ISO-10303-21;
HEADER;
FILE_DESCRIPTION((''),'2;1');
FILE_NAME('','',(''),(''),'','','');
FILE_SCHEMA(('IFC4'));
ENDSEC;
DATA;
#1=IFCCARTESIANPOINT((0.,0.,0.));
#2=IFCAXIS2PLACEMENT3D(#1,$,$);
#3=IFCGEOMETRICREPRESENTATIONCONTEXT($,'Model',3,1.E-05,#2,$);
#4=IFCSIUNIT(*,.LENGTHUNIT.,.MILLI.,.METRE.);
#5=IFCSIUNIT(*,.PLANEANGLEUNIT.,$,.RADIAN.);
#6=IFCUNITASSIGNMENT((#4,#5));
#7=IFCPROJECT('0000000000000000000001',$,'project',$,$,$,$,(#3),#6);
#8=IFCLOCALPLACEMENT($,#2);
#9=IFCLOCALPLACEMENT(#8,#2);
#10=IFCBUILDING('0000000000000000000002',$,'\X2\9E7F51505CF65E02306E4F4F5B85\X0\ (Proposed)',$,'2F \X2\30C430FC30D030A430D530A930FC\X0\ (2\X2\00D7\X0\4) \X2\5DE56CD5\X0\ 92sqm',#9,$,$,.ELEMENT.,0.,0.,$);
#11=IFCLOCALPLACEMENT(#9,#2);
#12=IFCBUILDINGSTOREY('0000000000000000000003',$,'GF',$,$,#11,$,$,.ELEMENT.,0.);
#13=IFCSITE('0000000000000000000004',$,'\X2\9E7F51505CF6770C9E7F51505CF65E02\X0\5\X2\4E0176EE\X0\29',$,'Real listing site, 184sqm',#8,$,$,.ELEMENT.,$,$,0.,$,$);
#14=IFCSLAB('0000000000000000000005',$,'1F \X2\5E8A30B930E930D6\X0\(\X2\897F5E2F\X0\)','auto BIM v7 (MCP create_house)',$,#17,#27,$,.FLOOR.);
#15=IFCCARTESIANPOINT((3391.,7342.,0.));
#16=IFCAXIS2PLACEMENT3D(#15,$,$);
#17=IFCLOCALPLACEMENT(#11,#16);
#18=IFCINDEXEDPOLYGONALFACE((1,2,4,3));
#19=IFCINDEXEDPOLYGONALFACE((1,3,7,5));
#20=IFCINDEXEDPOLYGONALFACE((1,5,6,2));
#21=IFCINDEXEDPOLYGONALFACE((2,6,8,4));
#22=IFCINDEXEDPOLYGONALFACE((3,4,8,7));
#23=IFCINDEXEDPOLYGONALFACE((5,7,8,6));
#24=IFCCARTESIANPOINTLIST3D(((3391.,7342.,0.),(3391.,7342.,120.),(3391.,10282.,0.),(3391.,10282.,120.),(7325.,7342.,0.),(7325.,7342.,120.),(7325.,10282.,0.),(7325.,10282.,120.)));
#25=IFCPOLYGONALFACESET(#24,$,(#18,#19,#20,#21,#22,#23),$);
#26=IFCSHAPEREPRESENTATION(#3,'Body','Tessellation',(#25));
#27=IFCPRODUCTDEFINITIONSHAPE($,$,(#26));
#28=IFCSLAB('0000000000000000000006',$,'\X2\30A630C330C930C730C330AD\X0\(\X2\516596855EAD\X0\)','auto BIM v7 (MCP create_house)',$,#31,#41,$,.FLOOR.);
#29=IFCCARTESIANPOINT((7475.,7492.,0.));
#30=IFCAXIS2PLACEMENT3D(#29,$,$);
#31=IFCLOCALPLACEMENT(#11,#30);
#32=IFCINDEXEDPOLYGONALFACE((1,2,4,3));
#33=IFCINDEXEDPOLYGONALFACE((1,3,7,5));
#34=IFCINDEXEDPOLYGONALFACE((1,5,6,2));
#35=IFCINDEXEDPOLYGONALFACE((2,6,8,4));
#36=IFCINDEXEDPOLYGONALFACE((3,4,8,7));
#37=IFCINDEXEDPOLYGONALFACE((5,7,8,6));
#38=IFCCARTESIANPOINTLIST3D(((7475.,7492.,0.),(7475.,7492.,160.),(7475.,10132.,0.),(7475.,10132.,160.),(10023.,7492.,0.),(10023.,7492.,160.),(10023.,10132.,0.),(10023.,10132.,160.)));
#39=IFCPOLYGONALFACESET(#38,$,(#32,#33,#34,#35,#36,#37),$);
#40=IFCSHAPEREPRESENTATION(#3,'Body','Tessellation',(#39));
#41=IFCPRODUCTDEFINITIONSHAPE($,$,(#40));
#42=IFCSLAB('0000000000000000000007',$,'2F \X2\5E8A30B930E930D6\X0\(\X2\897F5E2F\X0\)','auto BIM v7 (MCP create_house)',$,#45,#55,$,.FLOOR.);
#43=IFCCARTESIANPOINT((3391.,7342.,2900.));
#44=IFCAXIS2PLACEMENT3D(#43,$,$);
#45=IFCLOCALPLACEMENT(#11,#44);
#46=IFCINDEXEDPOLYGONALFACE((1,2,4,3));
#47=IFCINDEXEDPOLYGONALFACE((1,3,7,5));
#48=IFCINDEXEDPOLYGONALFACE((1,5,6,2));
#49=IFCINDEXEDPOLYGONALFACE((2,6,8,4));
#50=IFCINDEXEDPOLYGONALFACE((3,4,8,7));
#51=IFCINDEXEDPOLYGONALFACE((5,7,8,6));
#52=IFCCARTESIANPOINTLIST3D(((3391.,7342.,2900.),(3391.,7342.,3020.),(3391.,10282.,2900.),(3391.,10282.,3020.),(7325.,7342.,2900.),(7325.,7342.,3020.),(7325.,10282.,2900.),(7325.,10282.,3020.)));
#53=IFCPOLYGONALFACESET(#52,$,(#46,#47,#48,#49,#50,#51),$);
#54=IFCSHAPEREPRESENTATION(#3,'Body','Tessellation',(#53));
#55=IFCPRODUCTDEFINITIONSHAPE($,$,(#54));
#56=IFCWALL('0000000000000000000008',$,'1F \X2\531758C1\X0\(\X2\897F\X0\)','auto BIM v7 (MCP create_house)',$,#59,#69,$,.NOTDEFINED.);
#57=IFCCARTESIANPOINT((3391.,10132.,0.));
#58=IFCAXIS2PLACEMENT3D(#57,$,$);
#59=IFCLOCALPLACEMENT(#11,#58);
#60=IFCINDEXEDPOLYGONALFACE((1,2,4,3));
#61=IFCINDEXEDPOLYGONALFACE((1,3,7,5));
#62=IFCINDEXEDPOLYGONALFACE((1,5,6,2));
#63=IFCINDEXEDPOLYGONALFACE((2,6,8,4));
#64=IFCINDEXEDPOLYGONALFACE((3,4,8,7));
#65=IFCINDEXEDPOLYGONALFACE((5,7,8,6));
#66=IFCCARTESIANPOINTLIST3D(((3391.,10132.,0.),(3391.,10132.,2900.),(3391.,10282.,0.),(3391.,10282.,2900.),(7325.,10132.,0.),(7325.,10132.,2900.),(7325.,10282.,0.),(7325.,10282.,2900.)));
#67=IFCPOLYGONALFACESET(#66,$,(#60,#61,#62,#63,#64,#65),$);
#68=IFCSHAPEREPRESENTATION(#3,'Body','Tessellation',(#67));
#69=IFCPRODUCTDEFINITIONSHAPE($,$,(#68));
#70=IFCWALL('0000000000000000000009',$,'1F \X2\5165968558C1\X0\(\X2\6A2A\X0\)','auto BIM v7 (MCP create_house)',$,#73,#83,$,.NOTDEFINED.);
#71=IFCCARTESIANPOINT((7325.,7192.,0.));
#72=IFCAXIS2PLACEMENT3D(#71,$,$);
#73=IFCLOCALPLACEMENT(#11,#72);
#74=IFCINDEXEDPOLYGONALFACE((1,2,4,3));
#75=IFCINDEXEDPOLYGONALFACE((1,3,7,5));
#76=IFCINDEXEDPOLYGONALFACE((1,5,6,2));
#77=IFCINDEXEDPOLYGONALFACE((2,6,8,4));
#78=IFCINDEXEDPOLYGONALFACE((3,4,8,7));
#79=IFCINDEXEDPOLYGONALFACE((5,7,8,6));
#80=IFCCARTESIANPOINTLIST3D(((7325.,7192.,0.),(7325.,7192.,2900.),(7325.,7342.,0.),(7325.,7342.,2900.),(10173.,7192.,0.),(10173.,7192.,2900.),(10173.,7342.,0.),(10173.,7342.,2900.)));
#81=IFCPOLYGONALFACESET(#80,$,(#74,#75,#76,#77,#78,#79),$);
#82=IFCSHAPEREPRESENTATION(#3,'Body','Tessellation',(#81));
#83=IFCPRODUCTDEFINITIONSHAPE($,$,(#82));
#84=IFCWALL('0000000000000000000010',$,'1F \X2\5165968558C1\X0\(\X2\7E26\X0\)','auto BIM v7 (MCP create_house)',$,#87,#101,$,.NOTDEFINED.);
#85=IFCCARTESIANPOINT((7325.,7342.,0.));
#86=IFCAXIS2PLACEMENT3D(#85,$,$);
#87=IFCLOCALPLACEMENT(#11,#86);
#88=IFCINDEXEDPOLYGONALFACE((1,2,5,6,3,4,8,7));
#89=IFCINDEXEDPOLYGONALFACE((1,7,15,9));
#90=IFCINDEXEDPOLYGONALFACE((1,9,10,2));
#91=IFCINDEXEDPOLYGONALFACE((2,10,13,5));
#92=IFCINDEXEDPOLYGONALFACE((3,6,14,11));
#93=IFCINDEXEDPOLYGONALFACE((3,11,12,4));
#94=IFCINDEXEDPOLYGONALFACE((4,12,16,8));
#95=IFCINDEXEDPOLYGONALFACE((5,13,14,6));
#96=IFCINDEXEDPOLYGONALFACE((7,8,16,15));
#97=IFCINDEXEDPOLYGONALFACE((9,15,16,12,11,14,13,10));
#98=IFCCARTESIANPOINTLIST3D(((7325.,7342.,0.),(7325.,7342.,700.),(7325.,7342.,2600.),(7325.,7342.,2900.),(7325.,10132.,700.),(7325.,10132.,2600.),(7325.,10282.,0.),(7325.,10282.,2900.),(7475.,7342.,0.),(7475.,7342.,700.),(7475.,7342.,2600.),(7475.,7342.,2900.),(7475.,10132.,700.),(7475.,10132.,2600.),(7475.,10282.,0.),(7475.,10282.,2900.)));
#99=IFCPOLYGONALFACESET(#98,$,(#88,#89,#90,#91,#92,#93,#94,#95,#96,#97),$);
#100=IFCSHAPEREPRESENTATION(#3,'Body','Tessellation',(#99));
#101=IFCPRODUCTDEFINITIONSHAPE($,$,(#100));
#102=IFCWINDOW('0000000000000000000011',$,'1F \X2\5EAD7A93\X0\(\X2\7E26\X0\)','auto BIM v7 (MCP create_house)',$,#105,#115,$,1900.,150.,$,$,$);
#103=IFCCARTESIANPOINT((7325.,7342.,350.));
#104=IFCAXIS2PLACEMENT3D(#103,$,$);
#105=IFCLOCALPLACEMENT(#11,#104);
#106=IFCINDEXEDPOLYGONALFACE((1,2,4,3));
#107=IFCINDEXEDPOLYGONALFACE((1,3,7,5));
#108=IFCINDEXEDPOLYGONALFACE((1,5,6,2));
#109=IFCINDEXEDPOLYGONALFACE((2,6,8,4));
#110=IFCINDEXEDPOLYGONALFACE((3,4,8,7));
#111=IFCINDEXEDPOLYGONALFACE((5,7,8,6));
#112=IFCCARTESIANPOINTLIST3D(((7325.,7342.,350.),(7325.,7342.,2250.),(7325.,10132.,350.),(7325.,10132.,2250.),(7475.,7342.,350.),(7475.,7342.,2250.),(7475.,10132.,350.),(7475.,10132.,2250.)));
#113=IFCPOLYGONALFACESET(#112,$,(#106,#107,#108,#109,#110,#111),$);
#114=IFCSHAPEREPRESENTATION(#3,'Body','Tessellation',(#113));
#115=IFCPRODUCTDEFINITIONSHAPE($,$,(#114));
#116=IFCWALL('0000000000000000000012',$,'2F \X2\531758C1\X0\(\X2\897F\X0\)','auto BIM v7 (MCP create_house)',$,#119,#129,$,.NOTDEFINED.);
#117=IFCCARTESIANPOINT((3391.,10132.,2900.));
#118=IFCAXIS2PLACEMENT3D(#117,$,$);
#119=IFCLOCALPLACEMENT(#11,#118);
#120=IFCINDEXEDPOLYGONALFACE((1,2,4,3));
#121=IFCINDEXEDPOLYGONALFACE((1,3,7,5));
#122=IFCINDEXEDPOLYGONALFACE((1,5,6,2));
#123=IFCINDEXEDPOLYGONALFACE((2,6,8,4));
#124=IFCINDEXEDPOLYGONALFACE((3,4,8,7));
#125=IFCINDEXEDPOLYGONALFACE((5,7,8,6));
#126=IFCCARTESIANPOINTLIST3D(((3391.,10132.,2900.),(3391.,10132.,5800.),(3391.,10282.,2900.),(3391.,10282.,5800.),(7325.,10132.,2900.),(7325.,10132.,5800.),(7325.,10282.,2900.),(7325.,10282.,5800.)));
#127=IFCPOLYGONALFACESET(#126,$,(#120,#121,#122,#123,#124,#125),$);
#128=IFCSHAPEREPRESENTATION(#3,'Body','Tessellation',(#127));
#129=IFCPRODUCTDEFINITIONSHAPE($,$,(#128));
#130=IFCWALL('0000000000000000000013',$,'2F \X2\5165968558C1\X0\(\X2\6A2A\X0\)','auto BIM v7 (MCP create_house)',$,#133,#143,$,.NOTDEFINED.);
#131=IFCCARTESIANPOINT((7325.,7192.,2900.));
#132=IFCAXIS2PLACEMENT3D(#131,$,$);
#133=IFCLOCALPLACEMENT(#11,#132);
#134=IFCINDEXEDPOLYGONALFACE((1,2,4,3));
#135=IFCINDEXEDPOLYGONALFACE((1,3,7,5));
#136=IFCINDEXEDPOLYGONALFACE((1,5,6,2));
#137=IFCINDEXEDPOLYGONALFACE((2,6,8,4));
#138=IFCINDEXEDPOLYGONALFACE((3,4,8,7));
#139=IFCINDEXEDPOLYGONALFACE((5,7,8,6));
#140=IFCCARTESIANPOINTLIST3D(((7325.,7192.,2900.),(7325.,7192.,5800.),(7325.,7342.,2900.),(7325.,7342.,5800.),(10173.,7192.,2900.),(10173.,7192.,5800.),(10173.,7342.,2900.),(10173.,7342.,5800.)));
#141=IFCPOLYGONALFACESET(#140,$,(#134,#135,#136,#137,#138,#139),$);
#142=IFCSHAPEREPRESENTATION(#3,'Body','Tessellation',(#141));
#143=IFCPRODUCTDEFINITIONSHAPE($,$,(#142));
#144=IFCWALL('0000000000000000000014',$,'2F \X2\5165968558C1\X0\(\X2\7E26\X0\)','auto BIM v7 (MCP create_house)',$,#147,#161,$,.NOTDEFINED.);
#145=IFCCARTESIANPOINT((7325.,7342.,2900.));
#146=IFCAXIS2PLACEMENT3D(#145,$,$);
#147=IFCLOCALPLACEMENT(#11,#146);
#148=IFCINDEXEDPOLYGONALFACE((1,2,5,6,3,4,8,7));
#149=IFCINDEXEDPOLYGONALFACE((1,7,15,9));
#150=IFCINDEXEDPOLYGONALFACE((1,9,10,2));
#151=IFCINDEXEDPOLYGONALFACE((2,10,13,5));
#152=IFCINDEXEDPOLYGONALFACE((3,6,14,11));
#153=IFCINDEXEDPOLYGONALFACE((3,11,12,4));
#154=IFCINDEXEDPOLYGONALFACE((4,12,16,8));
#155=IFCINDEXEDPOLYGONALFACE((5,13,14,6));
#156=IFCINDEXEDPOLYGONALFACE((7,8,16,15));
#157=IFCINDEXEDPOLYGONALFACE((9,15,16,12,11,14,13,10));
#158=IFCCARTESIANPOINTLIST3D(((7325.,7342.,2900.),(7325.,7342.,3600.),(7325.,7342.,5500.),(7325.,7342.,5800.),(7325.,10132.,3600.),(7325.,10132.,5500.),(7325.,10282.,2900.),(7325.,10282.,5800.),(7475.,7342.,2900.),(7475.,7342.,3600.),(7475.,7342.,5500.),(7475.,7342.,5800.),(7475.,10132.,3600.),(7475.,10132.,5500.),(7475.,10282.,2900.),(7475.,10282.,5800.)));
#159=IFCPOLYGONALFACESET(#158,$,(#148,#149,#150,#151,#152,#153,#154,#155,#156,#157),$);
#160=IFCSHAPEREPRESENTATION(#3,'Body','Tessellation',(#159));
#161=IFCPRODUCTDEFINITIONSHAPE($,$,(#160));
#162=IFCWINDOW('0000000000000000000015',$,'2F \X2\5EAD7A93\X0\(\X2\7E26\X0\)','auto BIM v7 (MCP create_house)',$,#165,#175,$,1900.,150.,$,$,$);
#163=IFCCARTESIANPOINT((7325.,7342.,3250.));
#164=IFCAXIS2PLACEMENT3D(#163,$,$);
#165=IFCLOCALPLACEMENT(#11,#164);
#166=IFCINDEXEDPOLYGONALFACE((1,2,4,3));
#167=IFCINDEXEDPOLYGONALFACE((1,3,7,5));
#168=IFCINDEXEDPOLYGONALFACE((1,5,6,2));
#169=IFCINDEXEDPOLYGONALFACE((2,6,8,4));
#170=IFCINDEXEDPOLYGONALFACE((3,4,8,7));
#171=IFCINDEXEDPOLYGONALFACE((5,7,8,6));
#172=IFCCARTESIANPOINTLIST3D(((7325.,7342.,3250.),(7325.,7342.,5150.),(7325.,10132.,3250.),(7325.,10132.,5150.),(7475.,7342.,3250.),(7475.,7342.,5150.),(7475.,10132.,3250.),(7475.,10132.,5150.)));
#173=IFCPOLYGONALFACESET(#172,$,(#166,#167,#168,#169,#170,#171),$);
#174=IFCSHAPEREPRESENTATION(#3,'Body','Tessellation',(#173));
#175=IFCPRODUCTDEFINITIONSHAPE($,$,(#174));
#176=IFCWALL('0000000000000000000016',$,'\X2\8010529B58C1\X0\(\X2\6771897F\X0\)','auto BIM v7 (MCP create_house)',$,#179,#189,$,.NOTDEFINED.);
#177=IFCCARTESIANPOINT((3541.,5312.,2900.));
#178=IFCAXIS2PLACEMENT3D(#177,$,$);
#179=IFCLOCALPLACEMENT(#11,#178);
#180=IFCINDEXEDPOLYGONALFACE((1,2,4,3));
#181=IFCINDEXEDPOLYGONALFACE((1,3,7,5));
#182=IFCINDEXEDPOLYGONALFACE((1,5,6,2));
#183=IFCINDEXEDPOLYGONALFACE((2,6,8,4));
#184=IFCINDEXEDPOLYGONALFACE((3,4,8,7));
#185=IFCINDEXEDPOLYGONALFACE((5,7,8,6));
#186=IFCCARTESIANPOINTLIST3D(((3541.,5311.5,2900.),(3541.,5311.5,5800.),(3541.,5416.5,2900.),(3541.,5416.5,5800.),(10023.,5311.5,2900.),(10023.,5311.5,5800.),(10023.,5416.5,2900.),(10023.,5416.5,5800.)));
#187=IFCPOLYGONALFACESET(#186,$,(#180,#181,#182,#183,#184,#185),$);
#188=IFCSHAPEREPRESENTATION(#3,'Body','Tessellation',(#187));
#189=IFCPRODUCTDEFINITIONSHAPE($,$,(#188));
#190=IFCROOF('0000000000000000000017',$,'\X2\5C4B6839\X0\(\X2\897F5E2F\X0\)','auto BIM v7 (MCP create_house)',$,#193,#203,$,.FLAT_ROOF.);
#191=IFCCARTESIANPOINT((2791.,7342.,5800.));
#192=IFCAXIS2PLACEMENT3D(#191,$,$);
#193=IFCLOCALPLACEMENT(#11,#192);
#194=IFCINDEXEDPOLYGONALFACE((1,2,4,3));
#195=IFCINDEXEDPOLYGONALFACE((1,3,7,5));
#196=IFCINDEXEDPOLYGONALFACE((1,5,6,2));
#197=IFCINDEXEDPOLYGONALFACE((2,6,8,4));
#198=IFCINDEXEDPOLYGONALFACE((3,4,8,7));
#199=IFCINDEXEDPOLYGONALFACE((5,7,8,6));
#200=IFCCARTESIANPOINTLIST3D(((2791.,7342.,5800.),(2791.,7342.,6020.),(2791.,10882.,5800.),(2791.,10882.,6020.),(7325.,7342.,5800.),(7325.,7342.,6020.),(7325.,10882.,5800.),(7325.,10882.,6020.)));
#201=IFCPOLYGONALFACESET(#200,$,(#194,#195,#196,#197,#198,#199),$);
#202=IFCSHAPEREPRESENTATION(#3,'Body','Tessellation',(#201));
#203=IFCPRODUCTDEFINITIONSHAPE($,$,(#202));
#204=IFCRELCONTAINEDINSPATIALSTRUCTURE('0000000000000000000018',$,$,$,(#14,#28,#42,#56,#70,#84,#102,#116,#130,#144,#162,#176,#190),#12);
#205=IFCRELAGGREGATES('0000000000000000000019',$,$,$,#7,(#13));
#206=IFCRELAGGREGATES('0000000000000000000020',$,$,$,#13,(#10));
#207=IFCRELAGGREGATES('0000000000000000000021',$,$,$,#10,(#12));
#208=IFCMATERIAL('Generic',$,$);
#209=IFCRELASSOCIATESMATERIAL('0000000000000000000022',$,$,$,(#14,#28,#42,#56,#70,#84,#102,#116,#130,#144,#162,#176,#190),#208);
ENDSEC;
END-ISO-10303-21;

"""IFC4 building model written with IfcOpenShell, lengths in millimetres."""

from ifc_helpers import new_model, si_unit, frame, frame_2d, origin, place, context, project, spatial, rectangle, extrude, material, element, fill, save


model = new_model("IFC4")

# Units and contexts
model_context = context("Model", 3, precision=1e-05, world=origin())
ifc_project = project(units=[si_unit("LENGTHUNIT", "METRE", prefix="MILLI"), si_unit("PLANEANGLEUNIT", "RADIAN")], contexts=[model_context])

# Site, building, storey
site_placement = place(None, origin())
site = spatial("IfcSite", under=ifc_project, at=site_placement, Name="鹿児島県鹿児島市5丁目29", ObjectType="Real listing site, 184sqm", CompositionType="ELEMENT", RefElevation=0.0)
building_placement = place(site_placement, origin())
building = spatial("IfcBuilding", under=site, at=building_placement, Name="鹿児島市の住宅 (Proposed)", ObjectType="2F ツーバイフォー (2×4) 工法 92sqm", CompositionType="ELEMENT", ElevationOfRefHeight=0.0, ElevationOfTerrain=0.0)
storey_placement = place(building_placement, origin())
storey = spatial("IfcBuildingStorey", under=building, at=storey_placement, Name="GF", CompositionType="ELEMENT", Elevation=0.0)

# Slabs
ifc_material = material(Name="Generic")
slab_1_placement = place(storey_placement, frame((3391.0, 7342.0, 0.0)))
element("IfcSlab", 1, at=slab_1_placement, inside=storey, material=ifc_material, Name="1F 床スラブ(西帯)", Description="auto BIM v7 (MCP create_house)", PredefinedType="FLOOR", context=model_context, shape_type="SweptSolid", body=[
    extrude(rectangle(XDim=3934.0, YDim=2940.0, at=frame_2d((1967.0, 1470.0))), frame((3391.0, 7342.0, 0.0)), (0.0, 0.0, 1.0), 120.0),
])
slab_2_placement = place(storey_placement, frame((7475.0, 7492.0, 0.0)))
element("IfcSlab", 2, at=slab_2_placement, inside=storey, material=ifc_material, Name="ウッドデッキ(入隅庭)", Description="auto BIM v7 (MCP create_house)", PredefinedType="FLOOR", context=model_context, shape_type="SweptSolid", body=[
    extrude(rectangle(XDim=2548.0, YDim=2640.0, at=frame_2d((1274.0, 1320.0))), frame((7475.0, 7492.0, 0.0)), (0.0, 0.0, 1.0), 160.0),
])
slab_3_placement = place(storey_placement, frame((3391.0, 7342.0, 2900.0)))
element("IfcSlab", 3, at=slab_3_placement, inside=storey, material=ifc_material, Name="2F 床スラブ(西帯)", Description="auto BIM v7 (MCP create_house)", PredefinedType="FLOOR", context=model_context, shape_type="SweptSolid", body=[
    extrude(rectangle(XDim=3934.0, YDim=2940.0, at=frame_2d((1967.0, 1470.0))), frame((3391.0, 7342.0, 2900.0)), (0.0, 0.0, 1.0), 120.0),
])

# Walls
wall_1_placement = place(storey_placement, frame((3391.0, 10132.0, 0.0)))
element("IfcWall", 4, at=wall_1_placement, inside=storey, material=ifc_material, Name="1F 北壁(西)", Description="auto BIM v7 (MCP create_house)", PredefinedType="NOTDEFINED", context=model_context, shape_type="SweptSolid", body=[
    extrude(rectangle(XDim=3934.0, YDim=150.0, at=frame_2d((1967.0, 75.0))), frame((3391.0, 10132.0, 0.0)), (0.0, 0.0, 1.0), 2900.0),
])
wall_2_placement = place(storey_placement, frame((7325.0, 7192.0, 0.0)))
element("IfcWall", 5, at=wall_2_placement, inside=storey, material=ifc_material, Name="1F 入隅壁(横)", Description="auto BIM v7 (MCP create_house)", PredefinedType="NOTDEFINED", context=model_context, shape_type="SweptSolid", body=[
    extrude(rectangle(XDim=2848.0, YDim=150.0, at=frame_2d((1424.0, 75.0))), frame((7325.0, 7192.0, 0.0)), (0.0, 0.0, 1.0), 2900.0),
])

# Wall, opening, window
wall_3_placement = place(storey_placement, frame((7325.0, 7342.0, 0.0)))
wall_3 = element("IfcWall", 6, at=wall_3_placement, inside=storey, material=ifc_material, Name="1F 入隅壁(縦)", Description="auto BIM v7 (MCP create_house)", PredefinedType="NOTDEFINED", context=model_context, shape_type="SweptSolid", body=[
    extrude(rectangle(XDim=150.0, YDim=2940.0, at=frame_2d((75.0, 1470.0))), frame((7325.0, 7342.0, 0.0)), (0.0, 0.0, 1.0), 2900.0),
])
opening_1_placement = place(storey_placement, frame((7325.0, 7342.0, 350.0)))
opening_1 = element("IfcOpeningElement", 7, at=opening_1_placement, cuts=wall_3, PredefinedType="NOTDEFINED", context=model_context, shape_type="SweptSolid", body=[
    extrude(rectangle(XDim=150.0, YDim=2790.0, at=frame_2d((75.0, 1395.0))), frame((7325.0, 7342.0, 350.0)), (0.0, 0.0, 1.0), 1900.0),
])
window_1_placement = place(storey_placement, frame((7325.0, 7342.0, 350.0)))
window_1 = element("IfcWindow", 8, at=window_1_placement, inside=storey, material=ifc_material, Name="1F 庭窓(縦)", Description="auto BIM v7 (MCP create_house)", OverallHeight=1900.0, OverallWidth=150.0, context=model_context, shape_type="SweptSolid", body=[
    extrude(rectangle(XDim=150.0, YDim=2790.0, at=frame_2d((75.0, 1395.0))), frame((7325.0, 7342.0, 350.0)), (0.0, 0.0, 1.0), 1900.0),
])
fill(opening_1, window_1)

# Walls
wall_4_placement = place(storey_placement, frame((3391.0, 10132.0, 2900.0)))
element("IfcWall", 9, at=wall_4_placement, inside=storey, material=ifc_material, Name="2F 北壁(西)", Description="auto BIM v7 (MCP create_house)", PredefinedType="NOTDEFINED", context=model_context, shape_type="SweptSolid", body=[
    extrude(rectangle(XDim=3934.0, YDim=150.0, at=frame_2d((1967.0, 75.0))), frame((3391.0, 10132.0, 2900.0)), (0.0, 0.0, 1.0), 2900.0),
])
wall_5_placement = place(storey_placement, frame((7325.0, 7192.0, 2900.0)))
element("IfcWall", 10, at=wall_5_placement, inside=storey, material=ifc_material, Name="2F 入隅壁(横)", Description="auto BIM v7 (MCP create_house)", PredefinedType="NOTDEFINED", context=model_context, shape_type="SweptSolid", body=[
    extrude(rectangle(XDim=2848.0, YDim=150.0, at=frame_2d((1424.0, 75.0))), frame((7325.0, 7192.0, 2900.0)), (0.0, 0.0, 1.0), 2900.0),
])

# Wall, opening, window
wall_6_placement = place(storey_placement, frame((7325.0, 7342.0, 2900.0)))
wall_6 = element("IfcWall", 11, at=wall_6_placement, inside=storey, material=ifc_material, Name="2F 入隅壁(縦)", Description="auto BIM v7 (MCP create_house)", PredefinedType="NOTDEFINED", context=model_context, shape_type="SweptSolid", body=[
    extrude(rectangle(XDim=150.0, YDim=2940.0, at=frame_2d((75.0, 1470.0))), frame((7325.0, 7342.0, 2900.0)), (0.0, 0.0, 1.0), 2900.0),
])
opening_2_placement = place(storey_placement, frame((7325.0, 7342.0, 3250.0)))
opening_2 = element("IfcOpeningElement", 12, at=opening_2_placement, cuts=wall_6, PredefinedType="NOTDEFINED", context=model_context, shape_type="SweptSolid", body=[
    extrude(rectangle(XDim=150.0, YDim=2790.0, at=frame_2d((75.0, 1395.0))), frame((7325.0, 7342.0, 3250.0)), (0.0, 0.0, 1.0), 1900.0),
])
window_2_placement = place(storey_placement, frame((7325.0, 7342.0, 3250.0)))
window_2 = element("IfcWindow", 13, at=window_2_placement, inside=storey, material=ifc_material, Name="2F 庭窓(縦)", Description="auto BIM v7 (MCP create_house)", OverallHeight=1900.0, OverallWidth=150.0, context=model_context, shape_type="SweptSolid", body=[
    extrude(rectangle(XDim=150.0, YDim=2790.0, at=frame_2d((75.0, 1395.0))), frame((7325.0, 7342.0, 3250.0)), (0.0, 0.0, 1.0), 1900.0),
])
fill(opening_2, window_2)

# Wall
wall_7_placement = place(storey_placement, frame((3541.0, 5312.0, 2900.0)))
element("IfcWall", 14, at=wall_7_placement, inside=storey, material=ifc_material, Name="耐力壁(東西)", Description="auto BIM v7 (MCP create_house)", PredefinedType="NOTDEFINED", context=model_context, shape_type="SweptSolid", body=[
    extrude(rectangle(XDim=6482.0, YDim=105.0, at=frame_2d((3241.0, 52.0))), frame((3541.0, 5312.0, 2900.0)), (0.0, 0.0, 1.0), 2900.0),
])

# Roof
for number, where, name in (
    (15, (2791.0, 7342.0, 5800.0), "屋根(西帯)"),
):
    element("IfcRoof", number, at=place(storey_placement, frame(where)), inside=storey, material=ifc_material, Name=name, Description="auto BIM v7 (MCP create_house)", PredefinedType="FLAT_ROOF", context=model_context, shape_type="SweptSolid", body=[
        extrude(rectangle(XDim=4534.0, YDim=3540.0, at=frame_2d((2267.0, 1770.0))), frame((2791.0, 7342.0, 5800.0)), (0.0, 0.0, 1.0), 220.0),
    ])

save(model, "model.ifc")
